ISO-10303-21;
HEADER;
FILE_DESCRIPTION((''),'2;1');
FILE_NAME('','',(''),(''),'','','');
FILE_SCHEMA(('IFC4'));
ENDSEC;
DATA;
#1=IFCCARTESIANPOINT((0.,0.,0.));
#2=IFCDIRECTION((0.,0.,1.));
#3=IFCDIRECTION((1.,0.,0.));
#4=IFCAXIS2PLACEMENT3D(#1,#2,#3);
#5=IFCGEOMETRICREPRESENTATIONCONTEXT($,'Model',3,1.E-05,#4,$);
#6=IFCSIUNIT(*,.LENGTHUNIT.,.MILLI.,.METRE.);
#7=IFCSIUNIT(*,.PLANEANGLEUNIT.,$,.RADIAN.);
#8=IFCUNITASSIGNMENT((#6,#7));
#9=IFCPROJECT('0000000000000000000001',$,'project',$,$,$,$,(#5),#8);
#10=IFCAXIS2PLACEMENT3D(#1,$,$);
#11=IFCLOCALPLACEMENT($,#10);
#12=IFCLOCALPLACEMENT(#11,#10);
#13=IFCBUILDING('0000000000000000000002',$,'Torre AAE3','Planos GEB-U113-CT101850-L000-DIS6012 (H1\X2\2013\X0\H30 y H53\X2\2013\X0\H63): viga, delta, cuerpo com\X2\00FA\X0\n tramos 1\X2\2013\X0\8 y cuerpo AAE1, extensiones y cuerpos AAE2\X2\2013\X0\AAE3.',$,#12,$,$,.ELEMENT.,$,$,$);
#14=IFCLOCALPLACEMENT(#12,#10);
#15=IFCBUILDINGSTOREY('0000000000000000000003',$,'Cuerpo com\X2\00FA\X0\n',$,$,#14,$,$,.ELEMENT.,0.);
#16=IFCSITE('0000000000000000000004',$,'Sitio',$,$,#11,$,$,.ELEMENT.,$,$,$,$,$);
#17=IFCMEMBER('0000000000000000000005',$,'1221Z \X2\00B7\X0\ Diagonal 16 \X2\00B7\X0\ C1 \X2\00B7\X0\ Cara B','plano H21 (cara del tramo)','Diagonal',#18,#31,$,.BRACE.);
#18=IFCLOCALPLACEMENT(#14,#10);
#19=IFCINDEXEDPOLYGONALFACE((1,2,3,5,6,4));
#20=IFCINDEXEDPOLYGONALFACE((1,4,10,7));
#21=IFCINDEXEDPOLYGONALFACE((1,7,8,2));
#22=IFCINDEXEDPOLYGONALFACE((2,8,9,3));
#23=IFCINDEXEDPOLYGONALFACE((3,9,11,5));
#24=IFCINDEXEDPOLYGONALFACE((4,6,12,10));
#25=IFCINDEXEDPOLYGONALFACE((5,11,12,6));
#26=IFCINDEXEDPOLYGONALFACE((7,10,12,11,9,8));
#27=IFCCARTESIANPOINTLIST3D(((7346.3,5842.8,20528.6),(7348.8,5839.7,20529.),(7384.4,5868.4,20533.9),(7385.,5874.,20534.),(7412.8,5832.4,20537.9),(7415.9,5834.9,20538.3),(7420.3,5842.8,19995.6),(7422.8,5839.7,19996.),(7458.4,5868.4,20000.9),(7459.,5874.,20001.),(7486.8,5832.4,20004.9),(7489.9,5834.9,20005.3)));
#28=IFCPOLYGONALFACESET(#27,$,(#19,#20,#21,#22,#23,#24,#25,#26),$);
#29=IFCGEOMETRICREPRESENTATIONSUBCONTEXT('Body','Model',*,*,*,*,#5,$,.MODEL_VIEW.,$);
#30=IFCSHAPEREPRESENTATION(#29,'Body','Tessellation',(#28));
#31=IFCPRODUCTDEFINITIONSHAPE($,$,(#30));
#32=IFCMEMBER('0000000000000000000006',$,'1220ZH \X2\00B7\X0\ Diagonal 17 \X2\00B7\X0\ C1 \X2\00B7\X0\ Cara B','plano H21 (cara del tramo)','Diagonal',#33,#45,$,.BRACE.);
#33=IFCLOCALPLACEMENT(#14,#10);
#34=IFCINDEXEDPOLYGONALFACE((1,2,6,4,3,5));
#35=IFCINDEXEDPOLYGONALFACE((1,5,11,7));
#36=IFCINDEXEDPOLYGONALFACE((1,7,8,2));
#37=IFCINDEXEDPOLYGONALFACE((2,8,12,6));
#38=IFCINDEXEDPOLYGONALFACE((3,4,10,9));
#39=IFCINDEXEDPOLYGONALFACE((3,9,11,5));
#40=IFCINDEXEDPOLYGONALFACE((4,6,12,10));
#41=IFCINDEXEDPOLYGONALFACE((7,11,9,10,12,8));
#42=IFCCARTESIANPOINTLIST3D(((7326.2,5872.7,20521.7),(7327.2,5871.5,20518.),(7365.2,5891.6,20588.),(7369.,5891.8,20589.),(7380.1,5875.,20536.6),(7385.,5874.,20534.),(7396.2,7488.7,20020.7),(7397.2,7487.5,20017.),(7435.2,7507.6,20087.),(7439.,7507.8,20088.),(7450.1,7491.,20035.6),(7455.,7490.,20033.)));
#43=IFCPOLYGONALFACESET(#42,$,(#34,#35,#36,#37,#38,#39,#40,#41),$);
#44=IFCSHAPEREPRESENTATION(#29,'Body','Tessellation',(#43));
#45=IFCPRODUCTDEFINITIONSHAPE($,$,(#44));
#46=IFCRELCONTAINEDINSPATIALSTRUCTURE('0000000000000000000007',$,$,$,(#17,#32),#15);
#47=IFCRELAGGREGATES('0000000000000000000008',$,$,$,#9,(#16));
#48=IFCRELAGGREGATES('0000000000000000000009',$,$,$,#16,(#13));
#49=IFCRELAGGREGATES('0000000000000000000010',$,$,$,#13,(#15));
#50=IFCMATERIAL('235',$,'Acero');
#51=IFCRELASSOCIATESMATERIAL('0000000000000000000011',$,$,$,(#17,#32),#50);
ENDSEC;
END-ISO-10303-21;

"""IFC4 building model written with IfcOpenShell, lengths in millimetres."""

from ifc_helpers import new_model, si_unit, frame, frame_2d, origin, origin_with_axes, place, context, subcontext, project, spatial, l_section, extrude, material, element, save


model = new_model("IFC4")

# Units and contexts
model_context = context("Model", 3, precision=1e-05, world=origin_with_axes())
body_context = subcontext(model_context, "Body", "Model", "MODEL_VIEW")
ifc_project = project(units=[si_unit("LENGTHUNIT", "METRE", prefix="MILLI"), si_unit("PLANEANGLEUNIT", "RADIAN")], contexts=[model_context])

# Site, building, storey
site_placement = place(None, origin())
site = spatial("IfcSite", under=ifc_project, at=site_placement, Name="Sitio", CompositionType="ELEMENT")
building_placement = place(site_placement, origin())
building = spatial("IfcBuilding", under=site, at=building_placement, Name="Torre AAE3", Description="Planos GEB-U113-CT101850-L000-DIS6012 (H1–H30 y H53–H63): viga, delta, cuerpo común tramos 1–8 y cuerpo AAE1, extensiones y cuerpos AAE2–AAE3.", CompositionType="ELEMENT")
storey_placement = place(building_placement, origin())
storey = spatial("IfcBuildingStorey", under=building, at=storey_placement, Name="Cuerpo común", CompositionType="ELEMENT", Elevation=0.0)

# Members
ifc_material_1 = material(Name="235", Category="Acero")
member_1_placement = place(storey_placement, frame((7459.0, 5874.0, 20001.0), z_axis=(-0.137518, 0.0, 0.990499), x_axis=(-0.773819, -0.624229, -0.107435)))
element("IfcMember", 1, at=member_1_placement, inside=storey, material=ifc_material_1, Name="1221Z · Diagonal 16 · C1 · Cara B", Description="plano H21 (cara del tramo)", ObjectType="Diagonal", PredefinedType="BRACE", context=body_context, shape_type="SweptSolid", body=[
    extrude(l_section(Depth=50.0, Width=50.0, Thickness=4.0, at=frame_2d((25.0, 25.0))), None, (0.0, 0.0, 1.0), 538.1),
])
member_2_placement = place(storey_placement, frame((7385.0, 5874.0, 20534.0), z_axis=(0.041339, 0.954334, -0.295867), x_axis=(-0.96295, -0.040927, -0.266555)))
element("IfcMember", 2, at=member_2_placement, inside=storey, material=ifc_material_1, Name="1220ZH · Diagonal 17 · C1 · Cara B", Description="plano H21 (cara del tramo)", ObjectType="Diagonal", PredefinedType="BRACE", context=body_context, shape_type="SweptSolid", body=[
    extrude(l_section(Depth=60.0, Width=60.0, Thickness=4.0, at=frame_2d((30.0, 30.0))), None, (0.0, 0.0, 1.0), 1693.3),
])

save(model, "model.ifc")
